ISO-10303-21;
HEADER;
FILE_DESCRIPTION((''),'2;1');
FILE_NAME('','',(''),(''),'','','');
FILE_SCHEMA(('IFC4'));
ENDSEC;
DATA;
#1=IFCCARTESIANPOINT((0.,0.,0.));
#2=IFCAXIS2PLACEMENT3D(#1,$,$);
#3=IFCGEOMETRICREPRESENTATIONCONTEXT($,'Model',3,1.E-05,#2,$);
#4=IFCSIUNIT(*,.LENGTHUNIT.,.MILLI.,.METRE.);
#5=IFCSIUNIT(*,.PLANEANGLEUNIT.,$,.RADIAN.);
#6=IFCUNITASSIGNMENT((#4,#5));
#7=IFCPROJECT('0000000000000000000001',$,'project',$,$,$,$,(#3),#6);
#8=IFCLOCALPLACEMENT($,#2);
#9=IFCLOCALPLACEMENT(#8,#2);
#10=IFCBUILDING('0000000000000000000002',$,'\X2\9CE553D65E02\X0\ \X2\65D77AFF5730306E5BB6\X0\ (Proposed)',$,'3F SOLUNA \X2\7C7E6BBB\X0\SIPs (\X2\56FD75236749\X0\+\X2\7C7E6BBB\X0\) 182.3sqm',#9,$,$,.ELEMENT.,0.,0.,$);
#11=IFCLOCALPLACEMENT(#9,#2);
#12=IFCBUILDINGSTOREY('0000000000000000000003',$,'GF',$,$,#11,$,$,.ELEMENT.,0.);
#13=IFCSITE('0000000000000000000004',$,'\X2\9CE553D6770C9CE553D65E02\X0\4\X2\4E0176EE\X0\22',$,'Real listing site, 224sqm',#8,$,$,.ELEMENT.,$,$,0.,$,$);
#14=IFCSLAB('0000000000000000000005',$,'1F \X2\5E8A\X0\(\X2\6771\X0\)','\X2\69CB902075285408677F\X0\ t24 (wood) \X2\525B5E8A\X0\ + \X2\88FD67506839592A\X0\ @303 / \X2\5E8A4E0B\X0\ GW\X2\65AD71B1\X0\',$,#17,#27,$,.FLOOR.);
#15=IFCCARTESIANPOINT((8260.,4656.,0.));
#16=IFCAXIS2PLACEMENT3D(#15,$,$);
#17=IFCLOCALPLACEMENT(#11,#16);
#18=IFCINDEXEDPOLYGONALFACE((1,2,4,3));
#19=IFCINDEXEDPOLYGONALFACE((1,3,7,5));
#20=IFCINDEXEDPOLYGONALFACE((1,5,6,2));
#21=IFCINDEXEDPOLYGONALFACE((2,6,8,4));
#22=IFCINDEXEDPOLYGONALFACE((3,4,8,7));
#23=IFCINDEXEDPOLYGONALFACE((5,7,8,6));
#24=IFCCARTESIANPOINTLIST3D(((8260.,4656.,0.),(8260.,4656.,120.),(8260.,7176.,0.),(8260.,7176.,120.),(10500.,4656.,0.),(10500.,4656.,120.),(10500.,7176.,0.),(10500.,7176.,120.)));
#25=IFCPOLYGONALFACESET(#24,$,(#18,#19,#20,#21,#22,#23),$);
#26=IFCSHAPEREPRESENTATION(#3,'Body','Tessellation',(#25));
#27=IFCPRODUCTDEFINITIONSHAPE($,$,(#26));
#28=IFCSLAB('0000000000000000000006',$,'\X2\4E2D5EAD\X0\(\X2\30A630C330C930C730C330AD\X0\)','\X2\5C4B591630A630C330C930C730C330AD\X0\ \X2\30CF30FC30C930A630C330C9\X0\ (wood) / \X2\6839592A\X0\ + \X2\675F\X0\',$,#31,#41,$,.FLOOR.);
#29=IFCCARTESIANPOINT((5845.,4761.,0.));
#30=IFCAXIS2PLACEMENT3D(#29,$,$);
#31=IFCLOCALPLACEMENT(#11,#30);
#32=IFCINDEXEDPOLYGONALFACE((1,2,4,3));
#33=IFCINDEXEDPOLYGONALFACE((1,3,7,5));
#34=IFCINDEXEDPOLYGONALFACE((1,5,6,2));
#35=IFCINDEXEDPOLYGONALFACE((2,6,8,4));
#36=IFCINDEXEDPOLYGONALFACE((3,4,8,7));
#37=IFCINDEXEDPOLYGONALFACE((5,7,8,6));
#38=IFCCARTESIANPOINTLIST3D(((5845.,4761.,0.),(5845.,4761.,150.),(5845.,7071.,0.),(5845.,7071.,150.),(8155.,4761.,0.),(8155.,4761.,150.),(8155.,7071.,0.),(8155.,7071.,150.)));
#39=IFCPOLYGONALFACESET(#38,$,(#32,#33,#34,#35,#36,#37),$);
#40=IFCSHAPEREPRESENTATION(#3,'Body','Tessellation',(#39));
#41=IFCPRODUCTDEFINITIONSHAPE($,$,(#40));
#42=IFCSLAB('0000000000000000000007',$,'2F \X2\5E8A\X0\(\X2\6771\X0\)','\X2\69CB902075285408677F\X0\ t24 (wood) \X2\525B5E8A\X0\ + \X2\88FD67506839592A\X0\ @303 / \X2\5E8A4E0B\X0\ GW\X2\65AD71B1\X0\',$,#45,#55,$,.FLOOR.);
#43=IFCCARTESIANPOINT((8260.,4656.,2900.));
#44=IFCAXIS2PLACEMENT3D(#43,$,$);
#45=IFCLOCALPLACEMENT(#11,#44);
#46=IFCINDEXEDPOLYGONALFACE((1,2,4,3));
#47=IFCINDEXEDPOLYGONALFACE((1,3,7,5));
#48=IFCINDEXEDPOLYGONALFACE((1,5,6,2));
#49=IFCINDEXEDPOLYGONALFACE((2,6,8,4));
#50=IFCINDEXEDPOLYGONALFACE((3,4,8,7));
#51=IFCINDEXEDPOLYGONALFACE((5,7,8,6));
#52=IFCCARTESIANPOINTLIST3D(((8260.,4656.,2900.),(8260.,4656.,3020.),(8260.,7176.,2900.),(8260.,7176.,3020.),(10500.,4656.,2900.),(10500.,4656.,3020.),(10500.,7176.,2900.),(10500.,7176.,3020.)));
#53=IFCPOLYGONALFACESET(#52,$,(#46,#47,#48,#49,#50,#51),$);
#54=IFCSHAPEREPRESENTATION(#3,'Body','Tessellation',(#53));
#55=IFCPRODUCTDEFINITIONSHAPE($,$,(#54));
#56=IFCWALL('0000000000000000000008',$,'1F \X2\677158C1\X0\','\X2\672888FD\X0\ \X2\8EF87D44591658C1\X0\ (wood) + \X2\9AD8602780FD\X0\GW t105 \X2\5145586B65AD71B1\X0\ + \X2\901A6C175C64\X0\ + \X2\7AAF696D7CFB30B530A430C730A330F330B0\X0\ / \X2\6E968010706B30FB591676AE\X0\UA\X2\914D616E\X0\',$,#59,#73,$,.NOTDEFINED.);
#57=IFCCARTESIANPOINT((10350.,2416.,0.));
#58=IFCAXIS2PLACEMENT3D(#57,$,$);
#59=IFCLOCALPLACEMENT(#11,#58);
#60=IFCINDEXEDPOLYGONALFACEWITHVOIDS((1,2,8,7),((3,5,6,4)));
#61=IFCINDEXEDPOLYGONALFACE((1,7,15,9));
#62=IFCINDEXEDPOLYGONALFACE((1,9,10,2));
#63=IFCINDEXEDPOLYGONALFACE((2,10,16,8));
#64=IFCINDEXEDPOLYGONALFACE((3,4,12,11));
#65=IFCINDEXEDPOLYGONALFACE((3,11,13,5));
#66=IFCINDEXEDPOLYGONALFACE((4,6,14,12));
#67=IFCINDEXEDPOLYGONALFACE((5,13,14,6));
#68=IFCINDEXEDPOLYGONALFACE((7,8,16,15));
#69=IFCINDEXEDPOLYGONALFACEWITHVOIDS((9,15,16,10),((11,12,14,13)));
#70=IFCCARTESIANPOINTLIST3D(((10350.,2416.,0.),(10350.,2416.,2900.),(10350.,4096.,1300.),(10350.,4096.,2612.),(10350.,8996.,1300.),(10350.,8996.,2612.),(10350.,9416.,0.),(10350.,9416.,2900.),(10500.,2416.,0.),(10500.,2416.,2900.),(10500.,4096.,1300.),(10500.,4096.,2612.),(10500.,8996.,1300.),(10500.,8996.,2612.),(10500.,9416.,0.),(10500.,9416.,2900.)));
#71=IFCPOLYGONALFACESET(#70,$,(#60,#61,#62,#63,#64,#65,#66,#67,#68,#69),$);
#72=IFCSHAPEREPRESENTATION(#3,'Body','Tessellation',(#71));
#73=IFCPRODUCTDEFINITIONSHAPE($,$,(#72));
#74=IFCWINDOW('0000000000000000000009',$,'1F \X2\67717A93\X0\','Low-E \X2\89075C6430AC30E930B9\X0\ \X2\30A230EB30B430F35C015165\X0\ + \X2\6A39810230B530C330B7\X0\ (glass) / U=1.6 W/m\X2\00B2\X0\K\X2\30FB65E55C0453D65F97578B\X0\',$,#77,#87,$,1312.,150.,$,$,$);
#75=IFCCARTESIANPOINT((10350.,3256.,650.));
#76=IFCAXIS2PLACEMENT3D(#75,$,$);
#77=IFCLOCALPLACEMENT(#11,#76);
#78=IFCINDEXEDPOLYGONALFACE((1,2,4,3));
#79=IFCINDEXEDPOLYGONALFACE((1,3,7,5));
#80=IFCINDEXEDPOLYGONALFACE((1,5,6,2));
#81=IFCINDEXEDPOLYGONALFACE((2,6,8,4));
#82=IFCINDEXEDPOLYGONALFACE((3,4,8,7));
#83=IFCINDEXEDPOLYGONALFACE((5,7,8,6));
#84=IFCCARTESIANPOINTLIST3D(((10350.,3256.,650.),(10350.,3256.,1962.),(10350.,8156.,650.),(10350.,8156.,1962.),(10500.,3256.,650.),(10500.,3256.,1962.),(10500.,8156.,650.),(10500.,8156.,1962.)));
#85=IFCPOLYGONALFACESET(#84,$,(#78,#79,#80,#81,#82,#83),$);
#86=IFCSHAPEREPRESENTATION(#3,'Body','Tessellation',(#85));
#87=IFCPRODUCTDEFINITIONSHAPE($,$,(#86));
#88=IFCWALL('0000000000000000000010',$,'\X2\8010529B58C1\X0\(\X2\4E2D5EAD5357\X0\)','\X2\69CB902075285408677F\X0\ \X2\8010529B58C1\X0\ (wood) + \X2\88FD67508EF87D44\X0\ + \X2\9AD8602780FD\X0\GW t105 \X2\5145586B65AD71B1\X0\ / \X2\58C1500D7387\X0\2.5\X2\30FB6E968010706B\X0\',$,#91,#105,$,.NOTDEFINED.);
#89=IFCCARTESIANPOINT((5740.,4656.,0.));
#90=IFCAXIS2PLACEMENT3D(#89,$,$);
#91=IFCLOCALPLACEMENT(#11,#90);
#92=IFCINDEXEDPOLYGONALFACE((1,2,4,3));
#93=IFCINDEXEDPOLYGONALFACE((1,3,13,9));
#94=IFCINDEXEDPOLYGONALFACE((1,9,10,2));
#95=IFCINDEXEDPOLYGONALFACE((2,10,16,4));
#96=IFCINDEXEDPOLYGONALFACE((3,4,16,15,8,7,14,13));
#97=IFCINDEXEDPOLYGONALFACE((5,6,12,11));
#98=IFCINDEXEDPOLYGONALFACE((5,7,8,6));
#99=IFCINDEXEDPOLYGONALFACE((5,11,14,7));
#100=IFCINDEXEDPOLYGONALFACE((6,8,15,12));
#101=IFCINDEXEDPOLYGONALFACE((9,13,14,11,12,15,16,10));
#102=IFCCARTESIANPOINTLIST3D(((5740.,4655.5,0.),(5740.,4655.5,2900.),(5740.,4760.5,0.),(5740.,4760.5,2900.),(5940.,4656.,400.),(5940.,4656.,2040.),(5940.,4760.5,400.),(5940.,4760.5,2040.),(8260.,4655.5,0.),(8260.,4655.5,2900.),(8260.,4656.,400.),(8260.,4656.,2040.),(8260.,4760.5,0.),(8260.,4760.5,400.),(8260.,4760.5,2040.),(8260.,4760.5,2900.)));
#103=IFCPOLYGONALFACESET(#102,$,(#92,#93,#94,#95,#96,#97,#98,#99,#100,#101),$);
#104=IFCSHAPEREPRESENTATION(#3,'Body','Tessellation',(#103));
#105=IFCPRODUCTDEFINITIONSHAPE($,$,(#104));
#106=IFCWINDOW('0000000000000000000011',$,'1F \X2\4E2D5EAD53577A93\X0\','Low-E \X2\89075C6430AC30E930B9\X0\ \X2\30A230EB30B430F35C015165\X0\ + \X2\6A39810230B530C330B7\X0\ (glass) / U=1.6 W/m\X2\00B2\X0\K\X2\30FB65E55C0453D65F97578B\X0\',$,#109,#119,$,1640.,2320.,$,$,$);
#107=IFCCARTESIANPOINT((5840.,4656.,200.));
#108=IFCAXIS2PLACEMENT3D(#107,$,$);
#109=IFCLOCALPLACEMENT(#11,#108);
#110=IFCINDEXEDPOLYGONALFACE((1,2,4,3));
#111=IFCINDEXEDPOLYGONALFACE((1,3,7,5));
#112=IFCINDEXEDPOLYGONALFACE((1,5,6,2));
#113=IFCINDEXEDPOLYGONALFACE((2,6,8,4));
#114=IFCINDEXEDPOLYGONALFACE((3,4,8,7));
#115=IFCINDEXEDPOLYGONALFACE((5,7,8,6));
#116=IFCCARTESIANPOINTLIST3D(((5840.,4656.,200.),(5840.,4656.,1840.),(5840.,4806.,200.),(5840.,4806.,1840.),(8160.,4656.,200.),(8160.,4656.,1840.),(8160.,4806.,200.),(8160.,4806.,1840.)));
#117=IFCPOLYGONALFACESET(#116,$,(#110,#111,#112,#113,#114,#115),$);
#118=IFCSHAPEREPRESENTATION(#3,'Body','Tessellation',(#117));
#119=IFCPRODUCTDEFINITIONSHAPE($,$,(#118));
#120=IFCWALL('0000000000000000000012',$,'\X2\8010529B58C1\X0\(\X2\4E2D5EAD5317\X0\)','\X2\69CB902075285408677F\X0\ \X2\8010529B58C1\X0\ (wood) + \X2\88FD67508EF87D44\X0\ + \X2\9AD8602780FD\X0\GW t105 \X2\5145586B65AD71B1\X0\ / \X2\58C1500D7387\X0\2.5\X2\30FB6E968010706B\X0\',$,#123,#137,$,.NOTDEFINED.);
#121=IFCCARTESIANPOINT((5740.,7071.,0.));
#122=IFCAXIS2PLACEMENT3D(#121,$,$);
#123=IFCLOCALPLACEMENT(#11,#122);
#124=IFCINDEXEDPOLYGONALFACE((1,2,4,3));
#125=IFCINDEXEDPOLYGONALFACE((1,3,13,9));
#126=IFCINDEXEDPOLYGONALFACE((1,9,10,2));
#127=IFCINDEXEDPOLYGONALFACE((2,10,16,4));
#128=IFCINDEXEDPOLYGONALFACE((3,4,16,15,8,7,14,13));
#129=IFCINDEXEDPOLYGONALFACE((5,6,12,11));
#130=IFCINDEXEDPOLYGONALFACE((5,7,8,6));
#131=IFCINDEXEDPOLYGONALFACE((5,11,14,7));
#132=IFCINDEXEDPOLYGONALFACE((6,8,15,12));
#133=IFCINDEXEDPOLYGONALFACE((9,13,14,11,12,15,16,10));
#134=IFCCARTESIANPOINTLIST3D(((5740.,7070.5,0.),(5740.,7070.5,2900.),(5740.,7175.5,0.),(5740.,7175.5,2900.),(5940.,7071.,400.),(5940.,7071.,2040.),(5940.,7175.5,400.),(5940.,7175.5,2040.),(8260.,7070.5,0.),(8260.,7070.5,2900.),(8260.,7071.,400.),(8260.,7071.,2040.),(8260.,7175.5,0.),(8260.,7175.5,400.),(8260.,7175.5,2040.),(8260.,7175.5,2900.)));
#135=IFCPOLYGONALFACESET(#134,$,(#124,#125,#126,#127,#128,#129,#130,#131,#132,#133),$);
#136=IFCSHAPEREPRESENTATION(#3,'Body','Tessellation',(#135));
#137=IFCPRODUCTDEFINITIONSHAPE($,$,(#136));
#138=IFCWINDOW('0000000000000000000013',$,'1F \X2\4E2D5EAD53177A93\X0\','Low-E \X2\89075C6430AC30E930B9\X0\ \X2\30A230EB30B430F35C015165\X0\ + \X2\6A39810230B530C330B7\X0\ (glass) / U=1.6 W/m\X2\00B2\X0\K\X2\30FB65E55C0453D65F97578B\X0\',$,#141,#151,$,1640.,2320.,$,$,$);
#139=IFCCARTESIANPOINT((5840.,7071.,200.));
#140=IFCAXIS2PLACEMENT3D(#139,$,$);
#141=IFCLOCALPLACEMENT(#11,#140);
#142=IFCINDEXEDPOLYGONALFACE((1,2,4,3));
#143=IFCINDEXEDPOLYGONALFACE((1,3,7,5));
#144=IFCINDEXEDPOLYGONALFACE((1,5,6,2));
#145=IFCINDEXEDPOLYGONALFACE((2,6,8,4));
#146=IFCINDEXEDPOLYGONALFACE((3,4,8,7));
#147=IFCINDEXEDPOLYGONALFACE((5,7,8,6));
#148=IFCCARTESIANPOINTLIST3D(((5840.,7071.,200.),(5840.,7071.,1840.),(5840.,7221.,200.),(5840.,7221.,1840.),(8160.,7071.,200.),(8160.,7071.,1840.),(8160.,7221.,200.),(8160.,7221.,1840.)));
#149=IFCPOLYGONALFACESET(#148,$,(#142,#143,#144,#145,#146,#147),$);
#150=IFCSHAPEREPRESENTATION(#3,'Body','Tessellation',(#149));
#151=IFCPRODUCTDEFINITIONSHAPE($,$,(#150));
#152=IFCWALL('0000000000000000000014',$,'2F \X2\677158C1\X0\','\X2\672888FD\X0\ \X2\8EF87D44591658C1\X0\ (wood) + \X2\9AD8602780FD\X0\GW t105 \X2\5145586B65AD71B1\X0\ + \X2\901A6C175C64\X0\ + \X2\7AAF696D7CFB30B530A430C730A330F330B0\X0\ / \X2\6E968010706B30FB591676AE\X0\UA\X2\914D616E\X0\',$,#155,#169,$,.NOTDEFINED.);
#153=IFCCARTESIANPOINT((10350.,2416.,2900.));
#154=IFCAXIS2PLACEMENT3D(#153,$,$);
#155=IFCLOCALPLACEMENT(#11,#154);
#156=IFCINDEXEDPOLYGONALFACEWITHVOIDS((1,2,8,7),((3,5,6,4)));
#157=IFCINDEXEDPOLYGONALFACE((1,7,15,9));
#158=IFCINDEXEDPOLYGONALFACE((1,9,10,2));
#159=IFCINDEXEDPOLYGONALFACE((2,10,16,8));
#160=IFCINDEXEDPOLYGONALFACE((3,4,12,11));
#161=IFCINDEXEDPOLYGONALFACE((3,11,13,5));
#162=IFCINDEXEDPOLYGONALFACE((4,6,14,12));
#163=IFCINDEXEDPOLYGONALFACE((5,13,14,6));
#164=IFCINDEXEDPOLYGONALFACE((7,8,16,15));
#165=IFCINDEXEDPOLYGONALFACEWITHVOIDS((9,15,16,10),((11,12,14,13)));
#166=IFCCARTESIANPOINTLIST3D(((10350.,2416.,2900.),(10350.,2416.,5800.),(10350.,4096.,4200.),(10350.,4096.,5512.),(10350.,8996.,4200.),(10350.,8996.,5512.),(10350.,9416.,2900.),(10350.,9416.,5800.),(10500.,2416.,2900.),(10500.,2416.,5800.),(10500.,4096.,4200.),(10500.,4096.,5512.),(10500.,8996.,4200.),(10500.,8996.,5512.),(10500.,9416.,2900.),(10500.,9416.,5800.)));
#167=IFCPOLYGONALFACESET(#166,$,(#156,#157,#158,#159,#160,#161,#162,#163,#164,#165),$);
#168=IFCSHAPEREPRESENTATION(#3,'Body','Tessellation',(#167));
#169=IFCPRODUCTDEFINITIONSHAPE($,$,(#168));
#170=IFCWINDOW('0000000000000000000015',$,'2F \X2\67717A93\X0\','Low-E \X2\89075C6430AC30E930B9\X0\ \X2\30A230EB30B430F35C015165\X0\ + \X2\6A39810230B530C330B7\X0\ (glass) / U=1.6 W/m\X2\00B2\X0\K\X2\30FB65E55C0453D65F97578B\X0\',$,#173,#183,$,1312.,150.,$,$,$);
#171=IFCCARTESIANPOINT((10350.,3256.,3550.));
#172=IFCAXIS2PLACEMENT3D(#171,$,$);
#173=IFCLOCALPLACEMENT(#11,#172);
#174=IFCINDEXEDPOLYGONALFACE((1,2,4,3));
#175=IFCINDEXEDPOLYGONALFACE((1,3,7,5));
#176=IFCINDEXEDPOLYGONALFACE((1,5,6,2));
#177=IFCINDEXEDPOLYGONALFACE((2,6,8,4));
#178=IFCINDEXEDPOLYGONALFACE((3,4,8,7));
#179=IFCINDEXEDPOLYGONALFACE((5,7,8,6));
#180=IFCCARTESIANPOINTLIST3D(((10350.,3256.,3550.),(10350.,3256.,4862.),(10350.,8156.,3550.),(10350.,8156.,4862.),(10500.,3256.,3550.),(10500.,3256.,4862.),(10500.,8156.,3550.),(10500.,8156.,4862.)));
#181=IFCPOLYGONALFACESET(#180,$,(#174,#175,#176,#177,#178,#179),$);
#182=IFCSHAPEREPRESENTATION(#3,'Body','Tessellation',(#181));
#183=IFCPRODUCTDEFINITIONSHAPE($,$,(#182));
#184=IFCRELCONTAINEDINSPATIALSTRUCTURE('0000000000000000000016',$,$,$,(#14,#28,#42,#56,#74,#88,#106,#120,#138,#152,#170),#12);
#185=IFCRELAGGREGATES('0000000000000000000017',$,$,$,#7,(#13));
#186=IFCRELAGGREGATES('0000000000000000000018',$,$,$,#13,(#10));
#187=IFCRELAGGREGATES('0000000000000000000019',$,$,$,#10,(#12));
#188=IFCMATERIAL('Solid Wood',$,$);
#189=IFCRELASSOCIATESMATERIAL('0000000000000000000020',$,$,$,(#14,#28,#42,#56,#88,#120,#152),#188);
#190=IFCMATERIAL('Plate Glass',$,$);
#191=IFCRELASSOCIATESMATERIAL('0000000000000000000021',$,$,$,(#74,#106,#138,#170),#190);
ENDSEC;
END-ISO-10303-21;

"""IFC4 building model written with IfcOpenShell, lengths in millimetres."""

from ifc_helpers import new_model, si_unit, frame, frame_2d, origin, place, context, project, spatial, rectangle, extrude, material, element, fill, save


model = new_model("IFC4")

# Units and contexts
model_context = context("Model", 3, precision=1e-05, world=origin())
ifc_project = project(units=[si_unit("LENGTHUNIT", "METRE", prefix="MILLI"), si_unit("PLANEANGLEUNIT", "RADIAN")], contexts=[model_context])

# Site, building, storey
site_placement = place(None, origin())
site = spatial("IfcSite", under=ifc_project, at=site_placement, Name="鳥取県鳥取市4丁目22", ObjectType="Real listing site, 224sqm", CompositionType="ELEMENT", RefElevation=0.0)
building_placement = place(site_placement, origin())
building = spatial("IfcBuilding", under=site, at=building_placement, Name="鳥取市 旗竿地の家 (Proposed)", ObjectType="3F SOLUNA 籾殻SIPs (国産杉+籾殻) 182.3sqm", CompositionType="ELEMENT", ElevationOfRefHeight=0.0, ElevationOfTerrain=0.0)
storey_placement = place(building_placement, origin())
storey = spatial("IfcBuildingStorey", under=building, at=storey_placement, Name="GF", CompositionType="ELEMENT", Elevation=0.0)

# Slabs
ifc_material_1 = material(Name="Solid Wood")
slab_1_placement = place(storey_placement, frame((8260.0, 4656.0, 0.0)))
element("IfcSlab", 1, at=slab_1_placement, inside=storey, material=ifc_material_1, Name="1F 床(東)", Description="構造用合板 t24 (wood) 剛床 + 製材根太 @303 / 床下 GW断熱", PredefinedType="FLOOR", context=model_context, shape_type="SweptSolid", body=[
    extrude(rectangle(XDim=2240.0, YDim=2520.0, at=frame_2d((1120.0, 1260.0))), frame((8260.0, 4656.0, 0.0)), (0.0, 0.0, 1.0), 120.0),
])
slab_2_placement = place(storey_placement, frame((5845.0, 4761.0, 0.0)))
element("IfcSlab", 2, at=slab_2_placement, inside=storey, material=ifc_material_1, Name="中庭(ウッドデッキ)", Description="屋外ウッドデッキ ハードウッド (wood) / 根太 + 束", PredefinedType="FLOOR", context=model_context, shape_type="SweptSolid", body=[
    extrude(rectangle(XDim=2310.0, YDim=2310.0, at=frame_2d((1155.0, 1155.0))), frame((5845.0, 4761.0, 0.0)), (0.0, 0.0, 1.0), 150.0),
])
slab_3_placement = place(storey_placement, frame((8260.0, 4656.0, 2900.0)))
element("IfcSlab", 3, at=slab_3_placement, inside=storey, material=ifc_material_1, Name="2F 床(東)", Description="構造用合板 t24 (wood) 剛床 + 製材根太 @303 / 床下 GW断熱", PredefinedType="FLOOR", context=model_context, shape_type="SweptSolid", body=[
    extrude(rectangle(XDim=2240.0, YDim=2520.0, at=frame_2d((1120.0, 1260.0))), frame((8260.0, 4656.0, 2900.0)), (0.0, 0.0, 1.0), 120.0),
])

# Walls, openings, windows
wall_1_placement = place(storey_placement, frame((10350.0, 2416.0, 0.0)))
wall_1 = element("IfcWall", 4, at=wall_1_placement, inside=storey, material=ifc_material_1, Name="1F 東壁", Description="木製 軸組外壁 (wood) + 高性能GW t105 充填断熱 + 通気層 + 窯業系サイディング / 準耐火・外皮UA配慮", PredefinedType="NOTDEFINED", context=model_context, shape_type="SweptSolid", body=[
    extrude(rectangle(XDim=150.0, YDim=7000.0, at=frame_2d((75.0, 3500.0))), frame((10350.0, 2416.0, 0.0)), (0.0, 0.0, 1.0), 2900.0),
])
opening_1_placement = place(storey_placement, frame((10350.0, 3256.0, 650.0)))
opening_1 = element("IfcOpeningElement", 5, at=opening_1_placement, cuts=wall_1, PredefinedType="NOTDEFINED", context=model_context, shape_type="SweptSolid", body=[
    extrude(rectangle(XDim=150.0, YDim=4900.0, at=frame_2d((75.0, 2450.0))), frame((10350.0, 3256.0, 650.0)), (0.0, 0.0, 1.0), 1312.0),
])
ifc_material_2 = material(Name="Plate Glass")
window_1_placement = place(storey_placement, frame((10350.0, 3256.0, 650.0)))
window_1 = element("IfcWindow", 6, at=window_1_placement, inside=storey, material=ifc_material_2, Name="1F 東窓", Description="Low-E 複層ガラス アルゴン封入 + 樹脂サッシ (glass) / U=1.6 W/m²K・日射取得型", OverallHeight=1312.0, OverallWidth=150.0, context=model_context, shape_type="SweptSolid", body=[
    extrude(rectangle(XDim=150.0, YDim=4900.0, at=frame_2d((75.0, 2450.0))), frame((10350.0, 3256.0, 650.0)), (0.0, 0.0, 1.0), 1312.0),
])
fill(opening_1, window_1)
wall_2_placement = place(storey_placement, frame((5740.0, 4656.0, 0.0)))
wall_2 = element("IfcWall", 7, at=wall_2_placement, inside=storey, material=ifc_material_1, Name="耐力壁(中庭南)", Description="構造用合板 耐力壁 (wood) + 製材軸組 + 高性能GW t105 充填断熱 / 壁倍率2.5・準耐火", PredefinedType="NOTDEFINED", context=model_context, shape_type="SweptSolid", body=[
    extrude(rectangle(XDim=2520.0, YDim=105.0, at=frame_2d((1260.0, 52.0))), frame((5740.0, 4656.0, 0.0)), (0.0, 0.0, 1.0), 2900.0),
])
opening_2_placement = place(storey_placement, frame((5840.0, 4656.0, 200.0)))
opening_2 = element("IfcOpeningElement", 8, at=opening_2_placement, cuts=wall_2, PredefinedType="NOTDEFINED", context=model_context, shape_type="SweptSolid", body=[
    extrude(rectangle(XDim=2320.0, YDim=150.0, at=frame_2d((1160.0, 75.0))), frame((5840.0, 4656.0, 200.0)), (0.0, 0.0, 1.0), 1640.0),
])
window_2_placement = place(storey_placement, frame((5840.0, 4656.0, 200.0)))
window_2 = element("IfcWindow", 9, at=window_2_placement, inside=storey, material=ifc_material_2, Name="1F 中庭南窓", Description="Low-E 複層ガラス アルゴン封入 + 樹脂サッシ (glass) / U=1.6 W/m²K・日射取得型", OverallHeight=1640.0, OverallWidth=2320.0, context=model_context, shape_type="SweptSolid", body=[
    extrude(rectangle(XDim=2320.0, YDim=150.0, at=frame_2d((1160.0, 75.0))), frame((5840.0, 4656.0, 200.0)), (0.0, 0.0, 1.0), 1640.0),
])
fill(opening_2, window_2)
wall_3_placement = place(storey_placement, frame((5740.0, 7071.0, 0.0)))
wall_3 = element("IfcWall", 10, at=wall_3_placement, inside=storey, material=ifc_material_1, Name="耐力壁(中庭北)", Description="構造用合板 耐力壁 (wood) + 製材軸組 + 高性能GW t105 充填断熱 / 壁倍率2.5・準耐火", PredefinedType="NOTDEFINED", context=model_context, shape_type="SweptSolid", body=[
    extrude(rectangle(XDim=2520.0, YDim=105.0, at=frame_2d((1260.0, 52.0))), frame((5740.0, 7071.0, 0.0)), (0.0, 0.0, 1.0), 2900.0),
])
opening_3_placement = place(storey_placement, frame((5840.0, 7071.0, 200.0)))
opening_3 = element("IfcOpeningElement", 11, at=opening_3_placement, cuts=wall_3, PredefinedType="NOTDEFINED", context=model_context, shape_type="SweptSolid", body=[
    extrude(rectangle(XDim=2320.0, YDim=150.0, at=frame_2d((1160.0, 75.0))), frame((5840.0, 7071.0, 200.0)), (0.0, 0.0, 1.0), 1640.0),
])
window_3_placement = place(storey_placement, frame((5840.0, 7071.0, 200.0)))
window_3 = element("IfcWindow", 12, at=window_3_placement, inside=storey, material=ifc_material_2, Name="1F 中庭北窓", Description="Low-E 複層ガラス アルゴン封入 + 樹脂サッシ (glass) / U=1.6 W/m²K・日射取得型", OverallHeight=1640.0, OverallWidth=2320.0, context=model_context, shape_type="SweptSolid", body=[
    extrude(rectangle(XDim=2320.0, YDim=150.0, at=frame_2d((1160.0, 75.0))), frame((5840.0, 7071.0, 200.0)), (0.0, 0.0, 1.0), 1640.0),
])
fill(opening_3, window_3)

# Wall, opening, window
wall_4_placement = place(storey_placement, frame((10350.0, 2416.0, 2900.0)))
wall_4 = element("IfcWall", 13, at=wall_4_placement, inside=storey, material=ifc_material_1, Name="2F 東壁", Description="木製 軸組外壁 (wood) + 高性能GW t105 充填断熱 + 通気層 + 窯業系サイディング / 準耐火・外皮UA配慮", PredefinedType="NOTDEFINED", context=model_context, shape_type="SweptSolid", body=[
    extrude(rectangle(XDim=150.0, YDim=7000.0, at=frame_2d((75.0, 3500.0))), frame((10350.0, 2416.0, 2900.0)), (0.0, 0.0, 1.0), 2900.0),
])
opening_4_placement = place(storey_placement, frame((10350.0, 3256.0, 3550.0)))
opening_4 = element("IfcOpeningElement", 14, at=opening_4_placement, cuts=wall_4, PredefinedType="NOTDEFINED", context=model_context, shape_type="SweptSolid", body=[
    extrude(rectangle(XDim=150.0, YDim=4900.0, at=frame_2d((75.0, 2450.0))), frame((10350.0, 3256.0, 3550.0)), (0.0, 0.0, 1.0), 1312.0),
])
window_4_placement = place(storey_placement, frame((10350.0, 3256.0, 3550.0)))
window_4 = element("IfcWindow", 15, at=window_4_placement, inside=storey, material=ifc_material_2, Name="2F 東窓", Description="Low-E 複層ガラス アルゴン封入 + 樹脂サッシ (glass) / U=1.6 W/m²K・日射取得型", OverallHeight=1312.0, OverallWidth=150.0, context=model_context, shape_type="SweptSolid", body=[
    extrude(rectangle(XDim=150.0, YDim=4900.0, at=frame_2d((75.0, 2450.0))), frame((10350.0, 3256.0, 3550.0)), (0.0, 0.0, 1.0), 1312.0),
])
fill(opening_4, window_4)

save(model, "model.ifc")
